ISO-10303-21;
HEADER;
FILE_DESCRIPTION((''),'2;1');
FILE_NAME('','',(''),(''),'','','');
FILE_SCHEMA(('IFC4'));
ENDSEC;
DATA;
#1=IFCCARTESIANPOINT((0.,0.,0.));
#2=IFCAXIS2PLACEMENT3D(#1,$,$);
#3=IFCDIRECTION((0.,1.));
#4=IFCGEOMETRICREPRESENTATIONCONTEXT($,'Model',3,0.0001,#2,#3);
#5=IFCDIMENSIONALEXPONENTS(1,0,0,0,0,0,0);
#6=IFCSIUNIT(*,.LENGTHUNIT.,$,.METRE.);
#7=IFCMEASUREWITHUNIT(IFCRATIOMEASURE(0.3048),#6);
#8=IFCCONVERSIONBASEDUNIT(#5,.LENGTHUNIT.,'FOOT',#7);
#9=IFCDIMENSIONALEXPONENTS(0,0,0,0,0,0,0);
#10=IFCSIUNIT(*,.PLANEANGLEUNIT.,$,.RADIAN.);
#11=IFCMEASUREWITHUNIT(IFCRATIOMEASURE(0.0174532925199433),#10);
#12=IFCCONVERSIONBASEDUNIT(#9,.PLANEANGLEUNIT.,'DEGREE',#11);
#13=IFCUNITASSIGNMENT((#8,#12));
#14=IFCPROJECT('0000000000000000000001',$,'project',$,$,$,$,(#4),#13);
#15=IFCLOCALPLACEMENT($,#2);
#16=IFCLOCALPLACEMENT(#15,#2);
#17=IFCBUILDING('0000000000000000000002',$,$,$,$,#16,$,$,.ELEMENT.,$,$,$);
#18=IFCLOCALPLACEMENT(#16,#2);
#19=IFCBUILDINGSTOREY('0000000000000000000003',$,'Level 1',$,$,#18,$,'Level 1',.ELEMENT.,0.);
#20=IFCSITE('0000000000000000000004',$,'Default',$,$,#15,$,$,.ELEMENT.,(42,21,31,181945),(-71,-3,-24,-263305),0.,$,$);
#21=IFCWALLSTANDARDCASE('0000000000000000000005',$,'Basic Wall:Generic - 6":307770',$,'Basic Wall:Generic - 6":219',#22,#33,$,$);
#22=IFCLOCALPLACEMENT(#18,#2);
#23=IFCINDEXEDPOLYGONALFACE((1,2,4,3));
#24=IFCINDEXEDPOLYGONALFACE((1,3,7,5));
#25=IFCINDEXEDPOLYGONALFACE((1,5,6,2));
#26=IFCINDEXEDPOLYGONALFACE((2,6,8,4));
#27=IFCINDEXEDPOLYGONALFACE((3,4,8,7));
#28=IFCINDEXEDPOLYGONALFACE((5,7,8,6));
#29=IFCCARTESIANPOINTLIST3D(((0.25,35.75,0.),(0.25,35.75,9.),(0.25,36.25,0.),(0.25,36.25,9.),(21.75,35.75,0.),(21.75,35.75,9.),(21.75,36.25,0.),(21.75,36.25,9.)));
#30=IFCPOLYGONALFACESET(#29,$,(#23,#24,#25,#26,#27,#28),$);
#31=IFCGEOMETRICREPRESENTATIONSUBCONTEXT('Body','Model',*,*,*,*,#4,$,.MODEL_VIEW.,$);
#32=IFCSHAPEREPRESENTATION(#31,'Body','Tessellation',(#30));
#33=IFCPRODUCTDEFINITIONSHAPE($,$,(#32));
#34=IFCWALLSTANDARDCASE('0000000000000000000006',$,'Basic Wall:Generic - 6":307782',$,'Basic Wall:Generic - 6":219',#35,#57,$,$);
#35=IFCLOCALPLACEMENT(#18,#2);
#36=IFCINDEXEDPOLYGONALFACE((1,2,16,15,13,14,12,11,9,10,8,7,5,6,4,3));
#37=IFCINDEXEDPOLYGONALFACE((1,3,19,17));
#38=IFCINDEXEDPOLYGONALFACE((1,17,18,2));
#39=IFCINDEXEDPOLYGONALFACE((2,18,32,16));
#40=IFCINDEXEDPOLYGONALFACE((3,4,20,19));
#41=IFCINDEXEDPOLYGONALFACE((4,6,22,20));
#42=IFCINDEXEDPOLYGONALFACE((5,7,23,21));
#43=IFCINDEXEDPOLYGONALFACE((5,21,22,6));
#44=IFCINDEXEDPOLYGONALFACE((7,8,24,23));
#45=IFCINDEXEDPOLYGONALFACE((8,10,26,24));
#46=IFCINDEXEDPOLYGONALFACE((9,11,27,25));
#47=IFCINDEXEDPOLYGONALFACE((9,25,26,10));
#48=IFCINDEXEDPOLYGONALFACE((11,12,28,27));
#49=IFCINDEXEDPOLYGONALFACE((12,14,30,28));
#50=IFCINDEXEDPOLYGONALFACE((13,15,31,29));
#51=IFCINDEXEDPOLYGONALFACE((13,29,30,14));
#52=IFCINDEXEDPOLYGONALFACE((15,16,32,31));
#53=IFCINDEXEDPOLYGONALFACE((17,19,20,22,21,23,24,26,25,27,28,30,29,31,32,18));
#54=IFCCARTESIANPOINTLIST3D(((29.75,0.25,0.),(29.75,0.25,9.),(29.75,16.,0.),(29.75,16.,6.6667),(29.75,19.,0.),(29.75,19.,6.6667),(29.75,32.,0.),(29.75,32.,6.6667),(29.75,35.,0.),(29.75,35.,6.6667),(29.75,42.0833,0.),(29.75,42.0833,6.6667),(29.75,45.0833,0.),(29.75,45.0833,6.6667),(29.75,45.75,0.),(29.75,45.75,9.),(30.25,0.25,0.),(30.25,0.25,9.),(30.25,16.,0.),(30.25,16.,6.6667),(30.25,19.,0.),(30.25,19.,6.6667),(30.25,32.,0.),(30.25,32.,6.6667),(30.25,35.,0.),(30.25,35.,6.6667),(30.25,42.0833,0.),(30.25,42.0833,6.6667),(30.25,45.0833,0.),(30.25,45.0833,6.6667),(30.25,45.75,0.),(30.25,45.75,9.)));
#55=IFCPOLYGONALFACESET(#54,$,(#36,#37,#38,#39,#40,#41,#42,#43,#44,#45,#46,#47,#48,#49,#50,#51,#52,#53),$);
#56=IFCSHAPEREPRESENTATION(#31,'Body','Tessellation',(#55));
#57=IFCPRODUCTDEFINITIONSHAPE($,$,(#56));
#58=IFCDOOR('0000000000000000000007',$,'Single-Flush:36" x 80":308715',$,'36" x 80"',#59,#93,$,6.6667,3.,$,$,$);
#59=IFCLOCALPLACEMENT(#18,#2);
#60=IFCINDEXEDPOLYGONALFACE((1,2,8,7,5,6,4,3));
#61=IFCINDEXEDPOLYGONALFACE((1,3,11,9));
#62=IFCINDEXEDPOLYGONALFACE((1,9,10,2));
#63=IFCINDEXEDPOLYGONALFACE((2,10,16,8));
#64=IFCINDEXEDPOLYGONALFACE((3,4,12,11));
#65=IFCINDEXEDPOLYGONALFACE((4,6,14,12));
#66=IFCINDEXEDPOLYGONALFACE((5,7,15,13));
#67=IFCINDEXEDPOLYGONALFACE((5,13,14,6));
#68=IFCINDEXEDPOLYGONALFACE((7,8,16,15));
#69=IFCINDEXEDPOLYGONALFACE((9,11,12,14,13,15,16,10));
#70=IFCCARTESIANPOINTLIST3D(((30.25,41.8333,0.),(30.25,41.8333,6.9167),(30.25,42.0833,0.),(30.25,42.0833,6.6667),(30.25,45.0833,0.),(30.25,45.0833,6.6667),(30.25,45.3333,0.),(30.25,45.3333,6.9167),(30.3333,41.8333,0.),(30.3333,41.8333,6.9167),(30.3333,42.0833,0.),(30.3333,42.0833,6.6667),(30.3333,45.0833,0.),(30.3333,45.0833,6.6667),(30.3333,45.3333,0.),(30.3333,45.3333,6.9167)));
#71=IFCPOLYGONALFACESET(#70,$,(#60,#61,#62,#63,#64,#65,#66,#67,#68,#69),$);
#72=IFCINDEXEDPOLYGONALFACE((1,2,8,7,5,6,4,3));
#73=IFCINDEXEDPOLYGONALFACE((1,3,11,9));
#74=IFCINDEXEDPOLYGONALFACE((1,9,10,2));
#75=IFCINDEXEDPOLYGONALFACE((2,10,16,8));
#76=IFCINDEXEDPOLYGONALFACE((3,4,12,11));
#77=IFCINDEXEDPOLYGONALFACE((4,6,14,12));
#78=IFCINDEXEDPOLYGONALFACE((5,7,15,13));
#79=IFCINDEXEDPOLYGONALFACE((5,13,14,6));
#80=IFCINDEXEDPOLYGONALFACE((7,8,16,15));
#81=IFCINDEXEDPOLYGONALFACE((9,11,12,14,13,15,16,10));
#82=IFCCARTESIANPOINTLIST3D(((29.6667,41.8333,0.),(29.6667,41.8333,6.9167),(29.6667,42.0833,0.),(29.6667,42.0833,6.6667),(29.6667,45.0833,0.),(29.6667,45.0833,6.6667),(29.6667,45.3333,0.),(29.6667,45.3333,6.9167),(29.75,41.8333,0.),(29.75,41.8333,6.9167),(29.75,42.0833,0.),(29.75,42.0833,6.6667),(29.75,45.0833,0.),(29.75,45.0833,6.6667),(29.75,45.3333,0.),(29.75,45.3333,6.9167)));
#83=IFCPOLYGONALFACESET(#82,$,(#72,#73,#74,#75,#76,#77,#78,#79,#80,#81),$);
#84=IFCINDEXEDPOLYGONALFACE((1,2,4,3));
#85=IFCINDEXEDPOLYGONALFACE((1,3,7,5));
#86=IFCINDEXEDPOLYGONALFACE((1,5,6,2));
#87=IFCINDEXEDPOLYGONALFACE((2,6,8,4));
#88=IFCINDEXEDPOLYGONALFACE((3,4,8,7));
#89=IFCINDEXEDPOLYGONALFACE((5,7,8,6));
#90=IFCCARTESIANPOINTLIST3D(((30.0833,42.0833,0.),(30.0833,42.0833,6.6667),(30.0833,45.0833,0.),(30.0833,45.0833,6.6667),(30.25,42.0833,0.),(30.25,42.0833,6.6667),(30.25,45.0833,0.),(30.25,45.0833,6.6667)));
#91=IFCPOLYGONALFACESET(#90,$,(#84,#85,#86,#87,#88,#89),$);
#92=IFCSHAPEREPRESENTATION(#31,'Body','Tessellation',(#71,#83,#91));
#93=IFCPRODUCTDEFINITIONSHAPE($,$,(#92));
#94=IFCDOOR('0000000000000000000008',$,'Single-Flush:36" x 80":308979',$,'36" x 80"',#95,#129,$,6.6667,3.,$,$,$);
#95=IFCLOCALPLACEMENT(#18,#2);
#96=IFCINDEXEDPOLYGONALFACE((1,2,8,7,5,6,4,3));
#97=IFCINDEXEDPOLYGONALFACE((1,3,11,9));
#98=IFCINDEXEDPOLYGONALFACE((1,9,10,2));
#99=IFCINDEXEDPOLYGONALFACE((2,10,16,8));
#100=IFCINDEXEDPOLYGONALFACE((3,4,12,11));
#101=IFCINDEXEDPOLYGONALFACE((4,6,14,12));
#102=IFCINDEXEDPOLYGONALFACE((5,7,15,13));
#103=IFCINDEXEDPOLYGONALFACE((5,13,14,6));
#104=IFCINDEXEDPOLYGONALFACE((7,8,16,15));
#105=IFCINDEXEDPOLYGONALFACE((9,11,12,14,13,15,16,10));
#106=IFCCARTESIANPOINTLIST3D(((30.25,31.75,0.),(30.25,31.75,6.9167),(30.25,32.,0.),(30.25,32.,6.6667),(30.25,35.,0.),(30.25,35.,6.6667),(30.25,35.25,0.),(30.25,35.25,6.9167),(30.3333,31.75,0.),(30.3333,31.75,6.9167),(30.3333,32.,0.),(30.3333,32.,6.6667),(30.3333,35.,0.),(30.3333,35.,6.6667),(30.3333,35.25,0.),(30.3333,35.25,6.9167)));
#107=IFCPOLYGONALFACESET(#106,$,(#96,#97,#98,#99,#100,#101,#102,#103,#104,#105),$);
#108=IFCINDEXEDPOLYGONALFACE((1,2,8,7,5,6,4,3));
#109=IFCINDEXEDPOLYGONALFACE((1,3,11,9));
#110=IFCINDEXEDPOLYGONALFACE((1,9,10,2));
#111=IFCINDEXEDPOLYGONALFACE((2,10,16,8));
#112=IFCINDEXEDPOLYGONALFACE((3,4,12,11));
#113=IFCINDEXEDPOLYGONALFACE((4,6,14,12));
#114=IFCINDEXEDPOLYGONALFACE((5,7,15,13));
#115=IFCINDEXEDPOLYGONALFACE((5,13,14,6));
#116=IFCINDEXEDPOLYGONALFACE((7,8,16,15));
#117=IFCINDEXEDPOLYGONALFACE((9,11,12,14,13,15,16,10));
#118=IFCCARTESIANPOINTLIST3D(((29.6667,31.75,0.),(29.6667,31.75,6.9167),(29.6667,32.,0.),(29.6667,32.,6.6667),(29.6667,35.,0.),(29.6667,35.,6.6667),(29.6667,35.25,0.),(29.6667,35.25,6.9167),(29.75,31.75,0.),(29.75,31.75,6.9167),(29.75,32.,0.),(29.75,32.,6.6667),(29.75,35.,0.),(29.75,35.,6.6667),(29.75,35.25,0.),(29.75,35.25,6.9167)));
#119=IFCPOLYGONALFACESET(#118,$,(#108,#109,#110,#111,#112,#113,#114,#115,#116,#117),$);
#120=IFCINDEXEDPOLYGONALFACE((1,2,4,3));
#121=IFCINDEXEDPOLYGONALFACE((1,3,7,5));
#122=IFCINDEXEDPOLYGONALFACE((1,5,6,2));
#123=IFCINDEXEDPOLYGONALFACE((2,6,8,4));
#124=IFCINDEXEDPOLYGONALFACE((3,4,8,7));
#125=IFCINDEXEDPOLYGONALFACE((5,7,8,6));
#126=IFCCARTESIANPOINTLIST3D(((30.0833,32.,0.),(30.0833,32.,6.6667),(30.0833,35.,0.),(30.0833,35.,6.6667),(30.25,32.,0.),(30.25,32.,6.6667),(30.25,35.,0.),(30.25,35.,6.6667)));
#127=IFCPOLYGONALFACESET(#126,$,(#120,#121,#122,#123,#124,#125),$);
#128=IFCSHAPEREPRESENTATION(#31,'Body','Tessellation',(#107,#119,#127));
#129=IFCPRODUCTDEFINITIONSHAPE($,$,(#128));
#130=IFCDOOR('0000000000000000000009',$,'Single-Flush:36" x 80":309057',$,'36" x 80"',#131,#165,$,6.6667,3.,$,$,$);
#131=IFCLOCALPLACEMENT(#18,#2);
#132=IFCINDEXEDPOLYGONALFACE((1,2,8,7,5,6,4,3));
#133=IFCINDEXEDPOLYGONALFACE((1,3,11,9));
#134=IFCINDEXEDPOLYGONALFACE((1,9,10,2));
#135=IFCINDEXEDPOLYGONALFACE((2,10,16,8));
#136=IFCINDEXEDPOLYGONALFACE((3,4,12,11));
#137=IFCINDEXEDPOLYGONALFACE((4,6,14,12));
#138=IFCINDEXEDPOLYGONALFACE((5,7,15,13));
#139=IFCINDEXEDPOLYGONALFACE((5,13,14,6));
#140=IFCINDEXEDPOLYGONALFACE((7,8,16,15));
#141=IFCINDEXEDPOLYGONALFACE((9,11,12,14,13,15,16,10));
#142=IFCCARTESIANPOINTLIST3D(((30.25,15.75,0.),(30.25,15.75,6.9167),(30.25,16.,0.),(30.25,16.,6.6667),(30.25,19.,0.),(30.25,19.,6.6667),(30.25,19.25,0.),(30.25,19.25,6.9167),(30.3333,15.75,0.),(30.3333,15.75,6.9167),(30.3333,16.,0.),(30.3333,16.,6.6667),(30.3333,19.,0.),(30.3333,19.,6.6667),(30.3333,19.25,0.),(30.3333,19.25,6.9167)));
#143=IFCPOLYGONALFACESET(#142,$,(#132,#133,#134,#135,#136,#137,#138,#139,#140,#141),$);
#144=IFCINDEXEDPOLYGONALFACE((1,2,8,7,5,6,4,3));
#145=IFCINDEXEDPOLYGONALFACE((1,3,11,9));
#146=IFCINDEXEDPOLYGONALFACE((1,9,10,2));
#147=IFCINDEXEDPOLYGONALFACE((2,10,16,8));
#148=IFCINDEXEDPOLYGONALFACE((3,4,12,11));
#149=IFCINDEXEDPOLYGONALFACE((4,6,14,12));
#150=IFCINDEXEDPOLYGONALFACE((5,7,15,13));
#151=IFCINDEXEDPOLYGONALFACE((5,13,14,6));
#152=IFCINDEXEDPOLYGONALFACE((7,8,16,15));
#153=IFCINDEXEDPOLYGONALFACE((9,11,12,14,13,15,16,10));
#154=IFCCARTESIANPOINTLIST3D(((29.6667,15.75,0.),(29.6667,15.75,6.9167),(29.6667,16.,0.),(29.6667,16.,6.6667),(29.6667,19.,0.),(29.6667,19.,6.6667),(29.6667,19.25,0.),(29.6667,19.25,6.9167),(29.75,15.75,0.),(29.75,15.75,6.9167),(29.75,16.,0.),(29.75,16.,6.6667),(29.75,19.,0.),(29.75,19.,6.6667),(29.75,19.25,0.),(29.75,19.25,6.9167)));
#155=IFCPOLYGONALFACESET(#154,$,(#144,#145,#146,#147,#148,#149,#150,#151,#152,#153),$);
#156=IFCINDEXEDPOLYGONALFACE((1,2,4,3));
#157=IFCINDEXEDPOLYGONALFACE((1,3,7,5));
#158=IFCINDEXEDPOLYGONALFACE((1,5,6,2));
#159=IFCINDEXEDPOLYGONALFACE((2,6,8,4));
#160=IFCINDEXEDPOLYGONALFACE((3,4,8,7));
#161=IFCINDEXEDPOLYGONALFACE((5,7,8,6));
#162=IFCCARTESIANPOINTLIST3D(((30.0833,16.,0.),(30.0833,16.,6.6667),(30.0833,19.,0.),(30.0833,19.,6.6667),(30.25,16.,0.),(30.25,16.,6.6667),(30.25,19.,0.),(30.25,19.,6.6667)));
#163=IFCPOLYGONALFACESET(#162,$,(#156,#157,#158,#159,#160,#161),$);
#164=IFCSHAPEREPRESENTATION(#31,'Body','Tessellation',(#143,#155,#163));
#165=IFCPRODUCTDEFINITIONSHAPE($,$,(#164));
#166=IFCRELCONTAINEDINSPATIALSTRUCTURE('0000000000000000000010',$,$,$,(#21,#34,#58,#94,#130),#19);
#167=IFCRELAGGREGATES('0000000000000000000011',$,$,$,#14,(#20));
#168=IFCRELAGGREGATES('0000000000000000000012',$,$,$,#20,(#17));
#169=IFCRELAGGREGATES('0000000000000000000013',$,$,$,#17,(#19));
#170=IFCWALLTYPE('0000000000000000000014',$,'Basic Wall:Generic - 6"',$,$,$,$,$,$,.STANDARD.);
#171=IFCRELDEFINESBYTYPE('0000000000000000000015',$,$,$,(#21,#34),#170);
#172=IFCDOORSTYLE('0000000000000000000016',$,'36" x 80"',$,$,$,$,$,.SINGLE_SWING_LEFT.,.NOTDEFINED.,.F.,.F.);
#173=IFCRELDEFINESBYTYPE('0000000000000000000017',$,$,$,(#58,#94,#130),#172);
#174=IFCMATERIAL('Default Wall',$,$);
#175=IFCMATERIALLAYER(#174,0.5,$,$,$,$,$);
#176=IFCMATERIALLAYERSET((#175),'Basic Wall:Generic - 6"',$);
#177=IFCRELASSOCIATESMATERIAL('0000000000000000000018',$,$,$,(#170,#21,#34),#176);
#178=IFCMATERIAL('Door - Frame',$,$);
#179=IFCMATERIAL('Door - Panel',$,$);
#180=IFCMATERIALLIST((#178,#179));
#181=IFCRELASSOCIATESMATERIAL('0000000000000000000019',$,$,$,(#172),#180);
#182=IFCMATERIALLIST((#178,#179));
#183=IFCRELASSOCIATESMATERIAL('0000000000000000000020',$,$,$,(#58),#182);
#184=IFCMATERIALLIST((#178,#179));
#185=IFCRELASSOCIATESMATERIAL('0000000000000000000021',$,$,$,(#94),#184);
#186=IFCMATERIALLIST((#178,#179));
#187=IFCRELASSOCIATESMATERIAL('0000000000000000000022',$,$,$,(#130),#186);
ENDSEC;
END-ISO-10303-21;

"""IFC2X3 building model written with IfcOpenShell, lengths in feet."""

from ifc_helpers import new_model, entity, si_unit, converted_unit, direction, frame, frame_2d, origin, origin_2d_with_axis, place, context, subcontext, project, spatial, polyline, rectangle, outline, extrude, clip, bounded_halfspace, source, transform, mapped, material, material_list, layer, layer_set, layer_usage, type_object, type_shapes, element, fill, save


model = new_model("IFC2X3")

# Units and contexts
model_context = context("Model", 3, precision=0.0001, world=origin(), true_north=direction((0.0, 1.0)))
body_context = subcontext(model_context, "Body", "Model", "MODEL_VIEW")
ifc_project = project(units=[converted_unit("LENGTHUNIT", "FOOT", entity("IfcRatioMeasure", 0.3048), si_unit("LENGTHUNIT", "METRE"), dimensions=[1, 0, 0, 0, 0, 0, 0]), converted_unit("PLANEANGLEUNIT", "DEGREE", entity("IfcRatioMeasure", 0.0174532925199433), si_unit("PLANEANGLEUNIT", "RADIAN"), dimensions=[0, 0, 0, 0, 0, 0, 0])], contexts=[model_context])

# Site, building, storey
site_placement = place(None, origin())
site = spatial("IfcSite", under=ifc_project, at=site_placement, Name="Default", CompositionType="ELEMENT", RefLatitude=(42, 21, 31, 181945), RefLongitude=(-71, -3, -24, -263305), RefElevation=0.0)
building_placement = place(site_placement, origin())
building = spatial("IfcBuilding", under=site, at=building_placement, CompositionType="ELEMENT")
storey_placement = place(building_placement, origin())
storey = spatial("IfcBuildingStorey", under=building, at=storey_placement, Name="Level 1", LongName="Level 1", CompositionType="ELEMENT", Elevation=0.0)

# Shared definitions
ifc_material_1 = material(Name="Default Wall")
ifc_layer = layer(ifc_material_1, 0.5)
ifc_layer_set = layer_set([ifc_layer], Name="Basic Wall:Generic - 6\"")
wall_type = type_object("IfcWallType", Name="Basic Wall:Generic - 6\"", PredefinedType="STANDARD", material=ifc_layer_set)
ifc_material_2 = material(Name="Door - Frame")
ifc_material_3 = material(Name="Door - Panel")

# Wall
ifc_layer_usage_1 = layer_usage(ifc_layer_set, "AXIS2", "NEGATIVE", 0.25)
wall_1_placement = place(storey_placement, frame((0.25, 36.0, 0.0)))
element("IfcWallStandardCase", 1, at=wall_1_placement, inside=storey, type_object=wall_type, material=ifc_layer_usage_1, Name="Basic Wall:Generic - 6\":307770", ObjectType="Basic Wall:Generic - 6\":219", context=body_context, shape_type="Clipping", body=[
    clip(extrude(rectangle(XDim=21.5, YDim=0.5, at=frame_2d((10.75, 0.0), x_axis=(-1.0, 0.0))), origin(), (0.0, 0.0, 1.0), 9.0), bounded_halfspace(frame((0.0, -0.25, 9.0), z_axis=(0.0, 0.0, -1.0), x_axis=(-1.0, 0.0, 0.0)), True, frame((0.0, -0.25, 9.0)), polyline([(0.0, 0.0), (21.5, 0.0), (21.5, 0.5), (0.0, 0.5), (0.0, 0.0)]))),
])

# Wall, openings, doors
ifc_layer_usage_2 = layer_usage(ifc_layer_set, "AXIS2", "NEGATIVE", 0.25)
wall_2_placement = place(storey_placement, frame((30.0, 45.75, 0.0), z_axis=(0.0, 0.0, 1.0), x_axis=(0.0, -1.0, 0.0)))
wall_2 = element("IfcWallStandardCase", 2, at=wall_2_placement, inside=storey, type_object=wall_type, material=ifc_layer_usage_2, Name="Basic Wall:Generic - 6\":307782", ObjectType="Basic Wall:Generic - 6\":219", context=body_context, shape_type="Clipping", body=[
    clip(clip(clip(extrude(rectangle(XDim=45.5, YDim=0.5, at=frame_2d((22.75, 0.0), x_axis=(-1.0, 0.0))), origin(), (0.0, 0.0, 1.0), 9.0), bounded_halfspace(frame((34.0, -0.25, 9.0), z_axis=(0.0, 0.0, -1.0), x_axis=(0.0, 1.0, 0.0)), True, frame((34.0, -0.25, 9.0)), polyline([(0.0, 0.0), (11.5, 0.0), (11.5, 0.5), (0.0, 0.5), (0.0, 0.0)]))), bounded_halfspace(frame((25.5, -0.25, 9.0), z_axis=(0.0, 0.0, -1.0), x_axis=(-1.0, 0.0, 0.0)), True, frame((25.5, -0.25, 9.0)), polyline([(0.0, 0.0), (0.0, 0.5), (-15.5, 0.5), (-16.0, 0.5), (-25.5, 0.5), (-25.5, 0.0), (0.0, 0.0)]))), bounded_halfspace(frame((34.0, -0.25, 9.0), z_axis=(0.0, 0.0, -1.0), x_axis=(1.0, 0.0, 0.0)), True, frame((34.0, -0.25, 9.0)), polyline([(0.0, 0.0), (0.0, 0.5), (-8.0, 0.5), (-8.5, 0.5), (-8.5, 0.0), (-0.5, 0.0), (0.0, 0.0)]))),
])
opening_1_placement = place(wall_2_placement, frame((0.6667, -0.25, 0.0)))
opening_1 = element("IfcOpeningElement", 3, at=opening_1_placement, cuts=wall_2, ObjectType="Opening", context=body_context, shape_type="SweptSolid", body=[
    extrude(rectangle(XDim=3.0, YDim=6.6667, at=frame_2d((3.3333, 1.5), x_axis=(0.0, -1.0))), frame((0.0, 0.0, 0.0), z_axis=(0.0, 1.0, 0.0), x_axis=(0.0, 0.0, 1.0)), (0.0, 0.0, 1.0), 0.5),
])
opening_2_placement = place(wall_2_placement, frame((10.75, -0.25, 0.0)))
opening_2 = element("IfcOpeningElement", 4, at=opening_2_placement, cuts=wall_2, ObjectType="Opening", context=body_context, shape_type="SweptSolid", body=[
    extrude(rectangle(XDim=3.0, YDim=6.6667, at=frame_2d((3.3333, 1.5), x_axis=(0.0, -1.0))), frame((0.0, 0.0, 0.0), z_axis=(0.0, 1.0, 0.0), x_axis=(0.0, 0.0, 1.0)), (0.0, 0.0, 1.0), 0.5),
])
opening_3_placement = place(wall_2_placement, frame((26.75, -0.25, 0.0)))
opening_3 = element("IfcOpeningElement", 5, at=opening_3_placement, cuts=wall_2, ObjectType="Opening", context=body_context, shape_type="SweptSolid", body=[
    extrude(rectangle(XDim=3.0, YDim=6.6667, at=frame_2d((3.3333, 1.5), x_axis=(0.0, -1.0))), frame((0.0, 0.0, 0.0), z_axis=(0.0, 1.0, 0.0), x_axis=(0.0, 0.0, 1.0)), (0.0, 0.0, 1.0), 0.5),
])
ifc_material_list_1 = material_list([ifc_material_2, ifc_material_3])
ifc_material_list_2 = material_list([ifc_material_2, ifc_material_3])
door_style_1 = type_object("IfcDoorStyle", Name="36\" x 80\"", ConstructionType="NOTDEFINED", OperationType="SINGLE_SWING_LEFT", ParameterTakesPrecedence=False, Sizeable=False, material=ifc_material_list_2)
shared_shape_1 = source(origin(), body_context, "Body", "SweptSolid", [
    extrude(outline(polyline([(-1.75, -3.5208), (1.75, -3.5208), (1.75, 3.3958), (1.5, 3.3958), (1.5, -3.2708), (-1.5, -3.2708), (-1.5, 3.3958), (-1.75, 3.3958), (-1.75, -3.5208)])), frame((1.5, 0.5833, 3.3958), z_axis=(0.0, -1.0, 0.0), x_axis=(-1.0, 0.0, 0.0)), (0.0, 0.0, 1.0), 0.0833),
    extrude(outline(polyline([(-3.5208, -1.75), (3.3958, -1.75), (3.3958, -1.5), (-3.2708, -1.5), (-3.2708, 1.5), (3.3958, 1.5), (3.3958, 1.75), (-3.5208, 1.75), (-3.5208, -1.75)])), frame((1.5, 0.0, 3.3958), z_axis=(0.0, -1.0, 0.0), x_axis=(0.0, 0.0, -1.0)), (0.0, 0.0, 1.0), 0.0833),
    extrude(rectangle(XDim=3.0, YDim=0.1667, at=origin_2d_with_axis()), frame((1.5, 0.4167, 0.0)), (0.0, 0.0, 1.0), 6.6667),
])
type_shapes(door_style_1, [shared_shape_1])
door_1_placement = place(opening_1_placement, origin())
door_1 = element("IfcDoor", 6, at=door_1_placement, inside=storey, type_object=door_style_1, material=ifc_material_list_1, Name="Single-Flush:36\" x 80\":308715", ObjectType="36\" x 80\"", OverallHeight=6.6667, OverallWidth=3.0, context=body_context, shape_type="MappedRepresentation", body=[
    mapped(shared_shape_1, transform((0.0, 0.0, 0.0), scale=1.0)),
])
fill(opening_1, door_1)
ifc_material_list_3 = material_list([ifc_material_2, ifc_material_3])
door_2_placement = place(opening_2_placement, origin())
door_2 = element("IfcDoor", 7, at=door_2_placement, inside=storey, type_object=door_style_1, material=ifc_material_list_3, Name="Single-Flush:36\" x 80\":308979", ObjectType="36\" x 80\"", OverallHeight=6.6667, OverallWidth=3.0, context=body_context, shape_type="MappedRepresentation", body=[
    mapped(shared_shape_1, transform((0.0, 0.0, 0.0), scale=1.0)),
])
fill(opening_2, door_2)
ifc_material_list_4 = material_list([ifc_material_2, ifc_material_3])
door_3_placement = place(opening_3_placement, origin())
door_3 = element("IfcDoor", 8, at=door_3_placement, inside=storey, type_object=door_style_1, material=ifc_material_list_4, Name="Single-Flush:36\" x 80\":309057", ObjectType="36\" x 80\"", OverallHeight=6.6667, OverallWidth=3.0, context=body_context, shape_type="MappedRepresentation", body=[
    mapped(shared_shape_1, transform((0.0, 0.0, 0.0), scale=1.0)),
])
fill(opening_3, door_3)

save(model, "model.ifc")
